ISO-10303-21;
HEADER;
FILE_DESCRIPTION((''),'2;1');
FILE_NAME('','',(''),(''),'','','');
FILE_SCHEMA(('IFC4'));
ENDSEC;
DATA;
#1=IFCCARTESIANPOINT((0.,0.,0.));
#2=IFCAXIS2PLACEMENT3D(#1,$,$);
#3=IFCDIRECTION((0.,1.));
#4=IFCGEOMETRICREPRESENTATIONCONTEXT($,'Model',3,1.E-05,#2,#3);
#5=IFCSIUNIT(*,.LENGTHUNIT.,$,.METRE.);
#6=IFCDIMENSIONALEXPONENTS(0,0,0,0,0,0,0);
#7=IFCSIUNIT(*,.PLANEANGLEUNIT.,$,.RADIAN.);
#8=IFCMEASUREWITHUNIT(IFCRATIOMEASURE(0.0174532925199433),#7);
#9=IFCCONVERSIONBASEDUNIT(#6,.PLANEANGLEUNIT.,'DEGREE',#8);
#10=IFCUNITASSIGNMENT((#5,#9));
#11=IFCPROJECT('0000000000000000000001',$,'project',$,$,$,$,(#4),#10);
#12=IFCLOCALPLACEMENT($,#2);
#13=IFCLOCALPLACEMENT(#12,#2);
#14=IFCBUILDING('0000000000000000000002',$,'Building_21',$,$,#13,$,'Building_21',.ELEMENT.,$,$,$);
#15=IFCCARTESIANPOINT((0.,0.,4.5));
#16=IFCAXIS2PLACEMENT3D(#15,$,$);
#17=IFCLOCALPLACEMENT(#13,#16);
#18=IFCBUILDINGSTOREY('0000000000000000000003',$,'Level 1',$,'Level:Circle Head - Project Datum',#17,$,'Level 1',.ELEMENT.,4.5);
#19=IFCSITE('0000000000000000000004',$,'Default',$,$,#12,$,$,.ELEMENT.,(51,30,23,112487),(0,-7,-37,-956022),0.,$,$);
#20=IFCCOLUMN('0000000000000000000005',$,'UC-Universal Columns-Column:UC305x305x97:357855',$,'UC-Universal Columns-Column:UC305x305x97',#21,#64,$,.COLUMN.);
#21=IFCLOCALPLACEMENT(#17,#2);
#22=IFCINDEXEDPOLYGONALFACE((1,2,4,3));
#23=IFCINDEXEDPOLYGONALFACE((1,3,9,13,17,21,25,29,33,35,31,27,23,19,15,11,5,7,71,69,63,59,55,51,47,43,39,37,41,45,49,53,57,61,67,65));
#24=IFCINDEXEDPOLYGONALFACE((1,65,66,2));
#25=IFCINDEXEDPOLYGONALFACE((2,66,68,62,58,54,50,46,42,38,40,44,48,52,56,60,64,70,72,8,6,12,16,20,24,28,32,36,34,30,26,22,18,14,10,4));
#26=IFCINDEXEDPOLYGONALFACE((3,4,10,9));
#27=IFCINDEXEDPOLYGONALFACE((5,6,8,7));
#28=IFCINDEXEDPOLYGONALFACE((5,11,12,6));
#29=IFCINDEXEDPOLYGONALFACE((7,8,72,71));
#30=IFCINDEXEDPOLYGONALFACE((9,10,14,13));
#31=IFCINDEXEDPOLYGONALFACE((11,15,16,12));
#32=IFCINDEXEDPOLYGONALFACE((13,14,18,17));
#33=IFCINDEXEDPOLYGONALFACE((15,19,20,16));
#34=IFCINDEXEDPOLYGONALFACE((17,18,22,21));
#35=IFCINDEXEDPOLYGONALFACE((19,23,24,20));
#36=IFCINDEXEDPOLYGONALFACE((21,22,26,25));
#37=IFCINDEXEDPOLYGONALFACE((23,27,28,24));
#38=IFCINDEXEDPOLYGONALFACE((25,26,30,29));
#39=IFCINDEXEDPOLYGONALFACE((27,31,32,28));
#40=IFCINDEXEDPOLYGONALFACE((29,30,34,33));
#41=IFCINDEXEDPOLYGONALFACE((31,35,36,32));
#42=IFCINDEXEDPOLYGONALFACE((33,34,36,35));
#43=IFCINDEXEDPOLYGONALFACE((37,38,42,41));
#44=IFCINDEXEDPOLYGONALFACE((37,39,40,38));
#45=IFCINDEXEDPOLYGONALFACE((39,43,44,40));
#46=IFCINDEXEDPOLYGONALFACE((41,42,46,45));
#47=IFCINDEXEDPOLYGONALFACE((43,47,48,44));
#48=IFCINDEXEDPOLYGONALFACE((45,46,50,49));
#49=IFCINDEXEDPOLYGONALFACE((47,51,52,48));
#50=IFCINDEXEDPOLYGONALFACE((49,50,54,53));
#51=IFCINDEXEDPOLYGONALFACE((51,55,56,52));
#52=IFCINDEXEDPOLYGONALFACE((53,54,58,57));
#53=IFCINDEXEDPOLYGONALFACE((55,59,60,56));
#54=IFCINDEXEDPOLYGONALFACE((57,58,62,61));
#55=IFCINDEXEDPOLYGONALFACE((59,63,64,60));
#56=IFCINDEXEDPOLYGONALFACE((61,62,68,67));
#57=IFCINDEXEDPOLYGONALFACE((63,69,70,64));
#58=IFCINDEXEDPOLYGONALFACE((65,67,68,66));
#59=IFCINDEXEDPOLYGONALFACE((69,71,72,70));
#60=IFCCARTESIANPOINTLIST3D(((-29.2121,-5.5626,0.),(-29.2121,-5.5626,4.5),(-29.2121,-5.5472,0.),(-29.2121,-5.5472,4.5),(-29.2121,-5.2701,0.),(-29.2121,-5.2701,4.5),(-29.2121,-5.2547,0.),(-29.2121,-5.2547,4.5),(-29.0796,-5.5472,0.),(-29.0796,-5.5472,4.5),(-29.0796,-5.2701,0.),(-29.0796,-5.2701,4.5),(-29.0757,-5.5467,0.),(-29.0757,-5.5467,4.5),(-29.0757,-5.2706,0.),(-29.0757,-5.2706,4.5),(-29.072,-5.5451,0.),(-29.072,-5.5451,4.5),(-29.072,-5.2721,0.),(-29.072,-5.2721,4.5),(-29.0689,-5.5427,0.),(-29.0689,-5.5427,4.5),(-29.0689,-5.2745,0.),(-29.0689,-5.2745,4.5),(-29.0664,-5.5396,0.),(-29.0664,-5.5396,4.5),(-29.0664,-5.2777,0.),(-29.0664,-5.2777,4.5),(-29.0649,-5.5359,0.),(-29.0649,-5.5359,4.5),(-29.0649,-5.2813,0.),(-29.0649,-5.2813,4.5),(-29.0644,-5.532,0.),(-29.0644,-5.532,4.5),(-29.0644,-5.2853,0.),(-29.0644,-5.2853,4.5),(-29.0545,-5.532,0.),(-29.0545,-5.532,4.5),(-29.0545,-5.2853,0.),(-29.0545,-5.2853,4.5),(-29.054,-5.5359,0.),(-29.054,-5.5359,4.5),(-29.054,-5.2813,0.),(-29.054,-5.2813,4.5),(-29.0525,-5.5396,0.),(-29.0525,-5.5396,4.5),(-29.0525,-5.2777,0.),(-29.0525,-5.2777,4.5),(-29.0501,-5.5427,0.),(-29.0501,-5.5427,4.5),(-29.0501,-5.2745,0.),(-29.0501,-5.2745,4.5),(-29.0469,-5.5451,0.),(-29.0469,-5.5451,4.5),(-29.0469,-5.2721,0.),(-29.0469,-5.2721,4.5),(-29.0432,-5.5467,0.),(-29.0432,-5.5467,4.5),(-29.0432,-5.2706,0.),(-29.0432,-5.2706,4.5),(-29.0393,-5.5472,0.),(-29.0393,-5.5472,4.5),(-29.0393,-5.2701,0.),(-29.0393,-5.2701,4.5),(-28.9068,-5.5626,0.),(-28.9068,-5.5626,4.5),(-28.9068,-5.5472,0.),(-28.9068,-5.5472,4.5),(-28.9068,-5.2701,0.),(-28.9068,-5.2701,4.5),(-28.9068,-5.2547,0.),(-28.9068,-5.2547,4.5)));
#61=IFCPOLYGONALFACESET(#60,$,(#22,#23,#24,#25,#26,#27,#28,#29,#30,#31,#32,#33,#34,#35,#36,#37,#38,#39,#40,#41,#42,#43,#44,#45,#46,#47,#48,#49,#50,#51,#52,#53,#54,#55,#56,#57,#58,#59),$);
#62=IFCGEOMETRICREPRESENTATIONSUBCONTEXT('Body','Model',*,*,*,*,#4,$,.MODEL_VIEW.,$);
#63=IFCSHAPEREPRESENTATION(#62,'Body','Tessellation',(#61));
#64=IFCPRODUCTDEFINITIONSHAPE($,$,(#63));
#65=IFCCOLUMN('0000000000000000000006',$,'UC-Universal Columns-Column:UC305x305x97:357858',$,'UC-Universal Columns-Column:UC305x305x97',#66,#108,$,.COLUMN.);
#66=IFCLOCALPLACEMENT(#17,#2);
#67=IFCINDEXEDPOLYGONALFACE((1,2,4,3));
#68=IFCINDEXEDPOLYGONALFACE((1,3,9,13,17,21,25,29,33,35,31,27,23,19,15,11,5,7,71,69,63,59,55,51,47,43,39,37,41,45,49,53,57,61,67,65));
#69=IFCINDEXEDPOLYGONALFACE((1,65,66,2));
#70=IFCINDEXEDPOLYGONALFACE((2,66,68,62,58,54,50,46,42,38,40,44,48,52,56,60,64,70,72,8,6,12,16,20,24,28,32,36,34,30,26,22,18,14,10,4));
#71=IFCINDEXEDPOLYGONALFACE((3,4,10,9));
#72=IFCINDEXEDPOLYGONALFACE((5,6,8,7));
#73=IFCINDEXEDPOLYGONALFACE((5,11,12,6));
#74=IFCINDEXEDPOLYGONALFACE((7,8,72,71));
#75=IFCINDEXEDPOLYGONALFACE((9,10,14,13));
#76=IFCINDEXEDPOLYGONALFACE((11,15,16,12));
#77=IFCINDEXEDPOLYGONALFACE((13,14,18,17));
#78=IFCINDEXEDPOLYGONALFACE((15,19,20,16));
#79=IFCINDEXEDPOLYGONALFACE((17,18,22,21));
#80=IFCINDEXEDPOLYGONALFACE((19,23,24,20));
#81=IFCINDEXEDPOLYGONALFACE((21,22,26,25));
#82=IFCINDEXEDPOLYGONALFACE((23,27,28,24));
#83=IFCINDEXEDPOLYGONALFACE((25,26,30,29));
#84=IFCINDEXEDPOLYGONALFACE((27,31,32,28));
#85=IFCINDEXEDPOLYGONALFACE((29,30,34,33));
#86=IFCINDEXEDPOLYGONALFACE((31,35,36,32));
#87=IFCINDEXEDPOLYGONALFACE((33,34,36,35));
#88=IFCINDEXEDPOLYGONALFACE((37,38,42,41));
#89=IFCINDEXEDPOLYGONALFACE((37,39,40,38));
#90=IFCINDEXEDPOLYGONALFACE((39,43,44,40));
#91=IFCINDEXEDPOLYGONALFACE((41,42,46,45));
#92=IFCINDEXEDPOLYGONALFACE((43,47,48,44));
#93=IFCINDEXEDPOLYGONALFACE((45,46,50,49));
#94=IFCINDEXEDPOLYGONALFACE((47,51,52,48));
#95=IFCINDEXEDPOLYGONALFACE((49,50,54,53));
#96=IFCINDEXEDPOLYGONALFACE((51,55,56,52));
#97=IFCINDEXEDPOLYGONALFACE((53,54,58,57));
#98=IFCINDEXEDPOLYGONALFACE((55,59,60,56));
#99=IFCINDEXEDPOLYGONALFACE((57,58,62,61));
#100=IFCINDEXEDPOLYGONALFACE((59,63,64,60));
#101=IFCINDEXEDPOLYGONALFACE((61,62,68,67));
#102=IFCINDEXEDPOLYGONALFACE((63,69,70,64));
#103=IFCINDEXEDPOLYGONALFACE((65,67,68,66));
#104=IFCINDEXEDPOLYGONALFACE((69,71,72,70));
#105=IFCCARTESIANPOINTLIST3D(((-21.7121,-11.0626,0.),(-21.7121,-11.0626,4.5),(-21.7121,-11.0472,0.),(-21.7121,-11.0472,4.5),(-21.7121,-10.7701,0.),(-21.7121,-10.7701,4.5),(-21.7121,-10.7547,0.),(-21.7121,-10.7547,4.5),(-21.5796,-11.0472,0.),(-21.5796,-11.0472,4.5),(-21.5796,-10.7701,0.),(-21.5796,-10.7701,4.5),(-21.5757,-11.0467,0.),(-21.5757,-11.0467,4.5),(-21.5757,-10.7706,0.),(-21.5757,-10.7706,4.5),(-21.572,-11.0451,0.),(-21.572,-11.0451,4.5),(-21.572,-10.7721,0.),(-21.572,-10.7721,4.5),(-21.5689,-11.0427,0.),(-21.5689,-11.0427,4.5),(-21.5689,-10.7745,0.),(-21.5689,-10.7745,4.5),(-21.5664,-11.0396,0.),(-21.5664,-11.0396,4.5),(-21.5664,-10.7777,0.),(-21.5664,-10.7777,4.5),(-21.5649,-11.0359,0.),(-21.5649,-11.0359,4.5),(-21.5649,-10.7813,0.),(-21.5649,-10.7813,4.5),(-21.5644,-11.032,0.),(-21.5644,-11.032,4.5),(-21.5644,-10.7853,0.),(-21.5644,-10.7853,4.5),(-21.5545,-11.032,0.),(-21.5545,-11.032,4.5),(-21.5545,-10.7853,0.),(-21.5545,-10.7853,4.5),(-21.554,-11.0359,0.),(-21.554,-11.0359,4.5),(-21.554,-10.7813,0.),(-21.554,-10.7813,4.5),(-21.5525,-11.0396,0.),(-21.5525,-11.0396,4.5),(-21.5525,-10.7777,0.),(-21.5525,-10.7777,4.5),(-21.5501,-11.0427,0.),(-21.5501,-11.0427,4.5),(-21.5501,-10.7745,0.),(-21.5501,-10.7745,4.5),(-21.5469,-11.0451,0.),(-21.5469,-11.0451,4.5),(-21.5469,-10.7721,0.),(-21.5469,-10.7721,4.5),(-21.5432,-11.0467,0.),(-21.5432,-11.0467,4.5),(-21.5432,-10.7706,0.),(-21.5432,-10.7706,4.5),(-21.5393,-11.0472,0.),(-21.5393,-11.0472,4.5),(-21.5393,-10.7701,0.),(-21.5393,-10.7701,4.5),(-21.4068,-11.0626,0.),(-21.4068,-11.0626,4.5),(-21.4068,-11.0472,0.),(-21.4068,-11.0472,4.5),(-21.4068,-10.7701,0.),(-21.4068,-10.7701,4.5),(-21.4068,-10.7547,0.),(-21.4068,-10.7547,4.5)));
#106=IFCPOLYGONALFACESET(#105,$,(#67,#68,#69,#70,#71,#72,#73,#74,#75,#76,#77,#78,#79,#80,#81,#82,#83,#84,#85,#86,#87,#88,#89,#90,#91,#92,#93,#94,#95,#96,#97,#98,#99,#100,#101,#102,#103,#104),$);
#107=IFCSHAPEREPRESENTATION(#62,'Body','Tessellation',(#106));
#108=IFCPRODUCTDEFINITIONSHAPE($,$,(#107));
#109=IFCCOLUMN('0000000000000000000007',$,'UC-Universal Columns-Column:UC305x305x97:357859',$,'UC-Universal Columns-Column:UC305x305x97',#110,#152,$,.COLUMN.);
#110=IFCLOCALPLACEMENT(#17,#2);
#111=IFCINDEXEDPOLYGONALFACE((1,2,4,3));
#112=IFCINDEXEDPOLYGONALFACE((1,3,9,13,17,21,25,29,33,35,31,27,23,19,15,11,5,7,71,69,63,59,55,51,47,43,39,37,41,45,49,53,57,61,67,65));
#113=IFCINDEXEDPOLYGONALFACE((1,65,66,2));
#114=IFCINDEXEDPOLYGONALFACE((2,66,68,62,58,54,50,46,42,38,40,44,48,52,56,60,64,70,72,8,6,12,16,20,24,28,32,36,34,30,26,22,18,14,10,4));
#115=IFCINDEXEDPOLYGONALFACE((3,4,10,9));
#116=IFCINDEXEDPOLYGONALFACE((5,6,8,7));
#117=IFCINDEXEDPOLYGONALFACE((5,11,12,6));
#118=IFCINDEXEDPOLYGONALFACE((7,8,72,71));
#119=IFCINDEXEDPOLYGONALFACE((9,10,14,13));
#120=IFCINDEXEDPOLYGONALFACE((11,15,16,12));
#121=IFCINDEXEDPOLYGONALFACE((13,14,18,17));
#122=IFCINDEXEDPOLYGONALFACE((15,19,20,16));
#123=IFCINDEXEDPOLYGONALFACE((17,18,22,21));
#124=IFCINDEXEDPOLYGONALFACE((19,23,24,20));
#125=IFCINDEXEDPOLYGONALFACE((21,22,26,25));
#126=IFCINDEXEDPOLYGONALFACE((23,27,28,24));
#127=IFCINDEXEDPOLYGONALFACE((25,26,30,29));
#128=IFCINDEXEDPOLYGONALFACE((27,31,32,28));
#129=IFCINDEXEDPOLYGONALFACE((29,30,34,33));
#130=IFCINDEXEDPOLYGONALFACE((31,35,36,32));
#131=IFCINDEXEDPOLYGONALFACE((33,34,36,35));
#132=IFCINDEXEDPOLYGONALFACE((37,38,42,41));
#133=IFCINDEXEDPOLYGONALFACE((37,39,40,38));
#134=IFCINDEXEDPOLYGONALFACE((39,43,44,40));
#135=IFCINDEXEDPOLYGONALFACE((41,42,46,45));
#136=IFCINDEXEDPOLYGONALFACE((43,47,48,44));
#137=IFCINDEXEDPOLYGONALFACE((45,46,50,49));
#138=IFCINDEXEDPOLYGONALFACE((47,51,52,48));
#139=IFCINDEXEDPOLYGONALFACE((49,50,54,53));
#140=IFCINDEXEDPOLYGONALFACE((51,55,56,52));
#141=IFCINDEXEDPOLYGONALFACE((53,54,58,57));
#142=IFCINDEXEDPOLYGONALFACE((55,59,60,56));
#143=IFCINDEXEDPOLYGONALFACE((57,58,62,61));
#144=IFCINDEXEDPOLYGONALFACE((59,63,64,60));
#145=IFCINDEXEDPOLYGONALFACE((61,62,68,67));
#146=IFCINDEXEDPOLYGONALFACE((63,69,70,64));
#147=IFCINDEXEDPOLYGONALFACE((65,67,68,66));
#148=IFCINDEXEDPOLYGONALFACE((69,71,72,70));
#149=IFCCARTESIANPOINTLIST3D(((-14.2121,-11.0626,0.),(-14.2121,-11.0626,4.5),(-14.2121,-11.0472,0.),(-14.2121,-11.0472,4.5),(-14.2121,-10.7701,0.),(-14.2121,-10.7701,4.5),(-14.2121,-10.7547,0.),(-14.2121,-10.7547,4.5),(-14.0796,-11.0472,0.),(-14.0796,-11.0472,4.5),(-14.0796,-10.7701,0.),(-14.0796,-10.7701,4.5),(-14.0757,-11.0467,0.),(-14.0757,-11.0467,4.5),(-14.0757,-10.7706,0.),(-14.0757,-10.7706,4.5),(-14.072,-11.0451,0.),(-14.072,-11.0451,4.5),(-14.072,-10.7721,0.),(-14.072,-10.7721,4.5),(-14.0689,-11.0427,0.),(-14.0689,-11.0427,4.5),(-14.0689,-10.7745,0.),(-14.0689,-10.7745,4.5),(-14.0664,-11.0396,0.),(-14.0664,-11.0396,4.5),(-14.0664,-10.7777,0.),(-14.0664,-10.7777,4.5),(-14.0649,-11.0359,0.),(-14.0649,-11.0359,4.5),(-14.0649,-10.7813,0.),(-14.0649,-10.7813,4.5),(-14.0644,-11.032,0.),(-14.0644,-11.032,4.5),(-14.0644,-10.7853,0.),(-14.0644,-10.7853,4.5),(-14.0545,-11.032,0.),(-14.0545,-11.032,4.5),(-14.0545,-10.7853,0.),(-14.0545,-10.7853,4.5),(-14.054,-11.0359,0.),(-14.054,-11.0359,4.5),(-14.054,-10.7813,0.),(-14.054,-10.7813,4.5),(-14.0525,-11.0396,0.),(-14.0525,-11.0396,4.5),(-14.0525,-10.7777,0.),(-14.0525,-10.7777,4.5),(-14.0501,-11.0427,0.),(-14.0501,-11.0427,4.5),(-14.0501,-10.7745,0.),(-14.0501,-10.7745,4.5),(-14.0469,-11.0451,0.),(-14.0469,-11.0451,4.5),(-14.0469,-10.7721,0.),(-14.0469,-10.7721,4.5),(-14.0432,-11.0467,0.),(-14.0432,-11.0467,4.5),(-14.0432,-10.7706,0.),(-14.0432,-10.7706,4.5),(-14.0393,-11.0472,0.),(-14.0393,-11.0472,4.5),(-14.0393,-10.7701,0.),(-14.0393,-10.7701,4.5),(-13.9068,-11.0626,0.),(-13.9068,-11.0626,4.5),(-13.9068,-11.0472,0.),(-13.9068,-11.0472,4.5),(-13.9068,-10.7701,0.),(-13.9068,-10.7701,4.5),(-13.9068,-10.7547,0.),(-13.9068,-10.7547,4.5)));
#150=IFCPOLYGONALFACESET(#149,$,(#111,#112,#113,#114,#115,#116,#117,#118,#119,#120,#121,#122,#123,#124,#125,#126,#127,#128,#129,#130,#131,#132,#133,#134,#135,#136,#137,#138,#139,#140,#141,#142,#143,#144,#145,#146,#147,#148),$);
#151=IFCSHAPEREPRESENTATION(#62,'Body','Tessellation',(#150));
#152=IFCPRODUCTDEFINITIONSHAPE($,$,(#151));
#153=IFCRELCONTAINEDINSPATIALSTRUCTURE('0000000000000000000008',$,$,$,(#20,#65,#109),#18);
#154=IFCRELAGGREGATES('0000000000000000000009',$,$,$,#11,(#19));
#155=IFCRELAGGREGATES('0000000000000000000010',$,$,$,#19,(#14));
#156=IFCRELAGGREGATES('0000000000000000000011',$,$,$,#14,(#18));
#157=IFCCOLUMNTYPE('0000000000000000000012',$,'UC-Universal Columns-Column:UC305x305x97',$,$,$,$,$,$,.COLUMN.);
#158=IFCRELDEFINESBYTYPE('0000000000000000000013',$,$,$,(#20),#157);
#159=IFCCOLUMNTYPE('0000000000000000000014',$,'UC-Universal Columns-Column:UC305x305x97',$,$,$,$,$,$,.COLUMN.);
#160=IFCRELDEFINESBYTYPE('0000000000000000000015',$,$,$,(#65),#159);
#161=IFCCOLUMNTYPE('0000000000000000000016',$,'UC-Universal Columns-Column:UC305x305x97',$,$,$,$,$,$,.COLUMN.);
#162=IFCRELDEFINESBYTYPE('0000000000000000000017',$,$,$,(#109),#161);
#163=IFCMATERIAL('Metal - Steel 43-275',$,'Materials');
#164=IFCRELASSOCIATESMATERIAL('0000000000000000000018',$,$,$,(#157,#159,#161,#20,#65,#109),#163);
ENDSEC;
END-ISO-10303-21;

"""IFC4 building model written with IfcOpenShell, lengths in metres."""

from ifc_helpers import new_model, entity, si_unit, converted_unit, direction, frame, frame_2d, origin, place, context, subcontext, project, spatial, polyline, circle_curve, parameter, trimmed, segment, composite_curve, i_section, outline, extrude, source, transform, mapped, material, material_profile, profile_set, profile_usage, type_object, type_shapes, element, save


model = new_model("IFC4")

# Units and contexts
model_context = context("Model", 3, precision=1e-05, world=origin(), true_north=direction((0.0, 1.0)))
body_context = subcontext(model_context, "Body", "Model", "MODEL_VIEW")
ifc_project = project(units=[si_unit("LENGTHUNIT", "METRE"), converted_unit("PLANEANGLEUNIT", "DEGREE", entity("IfcRatioMeasure", 0.0174532925199433), si_unit("PLANEANGLEUNIT", "RADIAN"), dimensions=[0, 0, 0, 0, 0, 0, 0])], contexts=[model_context])

# Site, building, storey
site_placement = place(None, origin())
site = spatial("IfcSite", under=ifc_project, at=site_placement, Name="Default", CompositionType="ELEMENT", RefLatitude=(51, 30, 23, 112487), RefLongitude=(0, -7, -37, -956022), RefElevation=0.0)
building_placement = place(site_placement, origin())
building = spatial("IfcBuilding", under=site, at=building_placement, Name="Building_21", LongName="Building_21", CompositionType="ELEMENT")
storey_placement = place(building_placement, frame((0.0, 0.0, 4.5)))
storey = spatial("IfcBuildingStorey", under=building, at=storey_placement, Name="Level 1", ObjectType="Level:Circle Head - Project Datum", LongName="Level 1", CompositionType="ELEMENT", Elevation=4.5)

# Columns
ifc_material_1 = material(Name="Metal - Steel 43-275", Category="Materials")
ifc_material_profile_1 = material_profile(ifc_material_1, outline(composite_curve([segment(polyline([(-0.1527, 0.154, 0.0), (0.1527, 0.154, 0.0)]), True, "CONTINUOUS"), segment(polyline([(0.1527, 0.154, 0.0), (0.1527, 0.1386, 0.0)]), True, "CONTINUOUS"), segment(polyline([(0.1527, 0.1386, 0.0), (0.0201, 0.1386, 0.0)]), True, "CONTINUOUS"), segment(trimmed(circle_curve(frame((0.0201, 0.1234, 0.0)), 0.0152), [parameter(90.0)], [parameter(180.0)], True, "PARAMETER"), True, "CONTINUOUS"), segment(polyline([(0.0049, 0.1234, 0.0), (0.0049, -0.1234, 0.0)]), True, "CONTINUOUS"), segment(trimmed(circle_curve(frame((0.0201, -0.1234, 0.0)), 0.0152), [parameter(180.0)], [parameter(270.0)], True, "PARAMETER"), True, "CONTINUOUS"), segment(polyline([(0.0201, -0.1386, 0.0), (0.1527, -0.1386, 0.0)]), True, "CONTINUOUS"), segment(polyline([(0.1527, -0.1386, 0.0), (0.1527, -0.154, 0.0)]), True, "CONTINUOUS"), segment(polyline([(0.1527, -0.154, 0.0), (-0.1527, -0.154, 0.0)]), True, "CONTINUOUS"), segment(polyline([(-0.1527, -0.154, 0.0), (-0.1527, -0.1386, 0.0)]), True, "CONTINUOUS"), segment(polyline([(-0.1527, -0.1386, 0.0), (-0.0201, -0.1386, 0.0)]), True, "CONTINUOUS"), segment(trimmed(circle_curve(frame((-0.0201, -0.1234, 0.0)), 0.0152), [parameter(270.0)], [parameter(0.0)], True, "PARAMETER"), True, "CONTINUOUS"), segment(polyline([(-0.0049, -0.1234, 0.0), (-0.005, 0.1234, 0.0)]), True, "CONTINUOUS"), segment(trimmed(circle_curve(frame((-0.0201, 0.1234, 0.0)), 0.0152), [parameter(0.0)], [parameter(90.0)], True, "PARAMETER"), True, "CONTINUOUS"), segment(polyline([(-0.0201, 0.1386, 0.0), (-0.1527, 0.1386, 0.0)]), True, "CONTINUOUS"), segment(polyline([(-0.1527, 0.1386, 0.0), (-0.1527, 0.154, 0.0)]), True, "CONTINUOUS")], self_intersect=False), kind="CURVE"), Name="UC305x305x97")
ifc_material_profile_2 = material_profile(ifc_material_1, outline(composite_curve([segment(polyline([(0.1527, 0.154, 0.0), (0.1527, 0.1386, 0.0)]), True, "CONTINUOUS"), segment(polyline([(0.1527, 0.1386, 0.0), (0.0049, 0.1386, 0.0)]), True, "CONTINUOUS"), segment(polyline([(0.0049, 0.1386, 0.0), (0.0049, -0.1386, 0.0)]), True, "CONTINUOUS"), segment(polyline([(0.0049, -0.1386, 0.0), (0.1527, -0.1386, 0.0)]), True, "CONTINUOUS"), segment(polyline([(0.1527, -0.1386, 0.0), (0.1527, -0.154, 0.0)]), True, "CONTINUOUS"), segment(polyline([(0.1527, -0.154, 0.0), (-0.1527, -0.154, 0.0)]), True, "CONTINUOUS"), segment(polyline([(-0.1527, -0.154, 0.0), (-0.1527, -0.1386, 0.0)]), True, "CONTINUOUS"), segment(polyline([(-0.1527, -0.1386, 0.0), (-0.005, -0.1386, 0.0)]), True, "CONTINUOUS"), segment(polyline([(-0.005, -0.1386, 0.0), (-0.005, 0.1386, 0.0)]), True, "CONTINUOUS"), segment(polyline([(-0.005, 0.1386, 0.0), (-0.1527, 0.1386, 0.0)]), True, "CONTINUOUS"), segment(polyline([(-0.1527, 0.1386, 0.0), (-0.1527, 0.154, 0.0)]), True, "CONTINUOUS"), segment(polyline([(-0.1527, 0.154, 0.0), (0.1527, 0.154, 0.0)]), True, "CONTINUOUS")], self_intersect=False), kind="CURVE"), Name="UC305x305x97")
ifc_profile_set_1 = profile_set([ifc_material_profile_1, ifc_material_profile_2], Name="UC305x305x97")
ifc_profile_usage_1 = profile_usage(ifc_profile_set_1)
column_type_1 = type_object("IfcColumnType", Name="UC-Universal Columns-Column:UC305x305x97", PredefinedType="COLUMN", material=ifc_profile_set_1)
shared_shape_1 = source(origin(), body_context, "Body", "SweptSolid", [
    extrude(i_section(OverallWidth=0.3053, OverallDepth=0.3079, WebThickness=0.0099, FlangeThickness=0.0154, FilletRadius=0.0152, at=frame_2d((0.0, 0.0), x_axis=(0.0, 1.0))), frame((-29.0595, -5.4086, 4.5), z_axis=(0.0, 0.0, 1.0), x_axis=(0.0, -1.0, 0.0)), (0.0, 0.0, 1.0), 4.5),
])
type_shapes(column_type_1, [shared_shape_1])
column_1_placement = place(storey_placement, frame((0.0, 0.0, -4.5)))
element("IfcColumn", 1, at=column_1_placement, inside=storey, type_object=column_type_1, material=ifc_profile_usage_1, Name="UC-Universal Columns-Column:UC305x305x97:357855", ObjectType="UC-Universal Columns-Column:UC305x305x97", PredefinedType="COLUMN", context=body_context, shape_type="MappedRepresentation", body=[
    mapped(shared_shape_1, transform((0.0, 0.0, 0.0), scale=1.0)),
])
ifc_profile_usage_2 = profile_usage(ifc_profile_set_1)
column_type_2 = type_object("IfcColumnType", Name="UC-Universal Columns-Column:UC305x305x97", PredefinedType="COLUMN", material=ifc_profile_set_1)
shared_shape_2 = source(origin(), body_context, "Body", "SweptSolid", [
    extrude(i_section(OverallWidth=0.3053, OverallDepth=0.3079, WebThickness=0.0099, FlangeThickness=0.0154, FilletRadius=0.0152, at=frame_2d((0.0, 0.0), x_axis=(0.0, 1.0))), frame((-21.5595, -10.9086, 4.5), z_axis=(0.0, 0.0, 1.0), x_axis=(0.0, -1.0, 0.0)), (0.0, 0.0, 1.0), 4.5),
])
type_shapes(column_type_2, [shared_shape_2])
column_2_placement = place(storey_placement, frame((0.0, 0.0, -4.5)))
element("IfcColumn", 2, at=column_2_placement, inside=storey, type_object=column_type_2, material=ifc_profile_usage_2, Name="UC-Universal Columns-Column:UC305x305x97:357858", ObjectType="UC-Universal Columns-Column:UC305x305x97", PredefinedType="COLUMN", context=body_context, shape_type="MappedRepresentation", body=[
    mapped(shared_shape_2, transform((0.0, 0.0, 0.0), scale=1.0)),
])
ifc_profile_usage_3 = profile_usage(ifc_profile_set_1)
column_type_3 = type_object("IfcColumnType", Name="UC-Universal Columns-Column:UC305x305x97", PredefinedType="COLUMN", material=ifc_profile_set_1)
shared_shape_3 = source(origin(), body_context, "Body", "SweptSolid", [
    extrude(i_section(OverallWidth=0.3053, OverallDepth=0.3079, WebThickness=0.0099, FlangeThickness=0.0154, FilletRadius=0.0152, at=frame_2d((0.0, 0.0), x_axis=(0.0, 1.0))), frame((-14.0595, -10.9086, 4.5), z_axis=(0.0, 0.0, 1.0), x_axis=(0.0, -1.0, 0.0)), (0.0, 0.0, 1.0), 4.5),
])
type_shapes(column_type_3, [shared_shape_3])
column_3_placement = place(storey_placement, frame((0.0, 0.0, -4.5)))
element("IfcColumn", 3, at=column_3_placement, inside=storey, type_object=column_type_3, material=ifc_profile_usage_3, Name="UC-Universal Columns-Column:UC305x305x97:357859", ObjectType="UC-Universal Columns-Column:UC305x305x97", PredefinedType="COLUMN", context=body_context, shape_type="MappedRepresentation", body=[
    mapped(shared_shape_3, transform((0.0, 0.0, 0.0), scale=1.0)),
])

save(model, "model.ifc")
